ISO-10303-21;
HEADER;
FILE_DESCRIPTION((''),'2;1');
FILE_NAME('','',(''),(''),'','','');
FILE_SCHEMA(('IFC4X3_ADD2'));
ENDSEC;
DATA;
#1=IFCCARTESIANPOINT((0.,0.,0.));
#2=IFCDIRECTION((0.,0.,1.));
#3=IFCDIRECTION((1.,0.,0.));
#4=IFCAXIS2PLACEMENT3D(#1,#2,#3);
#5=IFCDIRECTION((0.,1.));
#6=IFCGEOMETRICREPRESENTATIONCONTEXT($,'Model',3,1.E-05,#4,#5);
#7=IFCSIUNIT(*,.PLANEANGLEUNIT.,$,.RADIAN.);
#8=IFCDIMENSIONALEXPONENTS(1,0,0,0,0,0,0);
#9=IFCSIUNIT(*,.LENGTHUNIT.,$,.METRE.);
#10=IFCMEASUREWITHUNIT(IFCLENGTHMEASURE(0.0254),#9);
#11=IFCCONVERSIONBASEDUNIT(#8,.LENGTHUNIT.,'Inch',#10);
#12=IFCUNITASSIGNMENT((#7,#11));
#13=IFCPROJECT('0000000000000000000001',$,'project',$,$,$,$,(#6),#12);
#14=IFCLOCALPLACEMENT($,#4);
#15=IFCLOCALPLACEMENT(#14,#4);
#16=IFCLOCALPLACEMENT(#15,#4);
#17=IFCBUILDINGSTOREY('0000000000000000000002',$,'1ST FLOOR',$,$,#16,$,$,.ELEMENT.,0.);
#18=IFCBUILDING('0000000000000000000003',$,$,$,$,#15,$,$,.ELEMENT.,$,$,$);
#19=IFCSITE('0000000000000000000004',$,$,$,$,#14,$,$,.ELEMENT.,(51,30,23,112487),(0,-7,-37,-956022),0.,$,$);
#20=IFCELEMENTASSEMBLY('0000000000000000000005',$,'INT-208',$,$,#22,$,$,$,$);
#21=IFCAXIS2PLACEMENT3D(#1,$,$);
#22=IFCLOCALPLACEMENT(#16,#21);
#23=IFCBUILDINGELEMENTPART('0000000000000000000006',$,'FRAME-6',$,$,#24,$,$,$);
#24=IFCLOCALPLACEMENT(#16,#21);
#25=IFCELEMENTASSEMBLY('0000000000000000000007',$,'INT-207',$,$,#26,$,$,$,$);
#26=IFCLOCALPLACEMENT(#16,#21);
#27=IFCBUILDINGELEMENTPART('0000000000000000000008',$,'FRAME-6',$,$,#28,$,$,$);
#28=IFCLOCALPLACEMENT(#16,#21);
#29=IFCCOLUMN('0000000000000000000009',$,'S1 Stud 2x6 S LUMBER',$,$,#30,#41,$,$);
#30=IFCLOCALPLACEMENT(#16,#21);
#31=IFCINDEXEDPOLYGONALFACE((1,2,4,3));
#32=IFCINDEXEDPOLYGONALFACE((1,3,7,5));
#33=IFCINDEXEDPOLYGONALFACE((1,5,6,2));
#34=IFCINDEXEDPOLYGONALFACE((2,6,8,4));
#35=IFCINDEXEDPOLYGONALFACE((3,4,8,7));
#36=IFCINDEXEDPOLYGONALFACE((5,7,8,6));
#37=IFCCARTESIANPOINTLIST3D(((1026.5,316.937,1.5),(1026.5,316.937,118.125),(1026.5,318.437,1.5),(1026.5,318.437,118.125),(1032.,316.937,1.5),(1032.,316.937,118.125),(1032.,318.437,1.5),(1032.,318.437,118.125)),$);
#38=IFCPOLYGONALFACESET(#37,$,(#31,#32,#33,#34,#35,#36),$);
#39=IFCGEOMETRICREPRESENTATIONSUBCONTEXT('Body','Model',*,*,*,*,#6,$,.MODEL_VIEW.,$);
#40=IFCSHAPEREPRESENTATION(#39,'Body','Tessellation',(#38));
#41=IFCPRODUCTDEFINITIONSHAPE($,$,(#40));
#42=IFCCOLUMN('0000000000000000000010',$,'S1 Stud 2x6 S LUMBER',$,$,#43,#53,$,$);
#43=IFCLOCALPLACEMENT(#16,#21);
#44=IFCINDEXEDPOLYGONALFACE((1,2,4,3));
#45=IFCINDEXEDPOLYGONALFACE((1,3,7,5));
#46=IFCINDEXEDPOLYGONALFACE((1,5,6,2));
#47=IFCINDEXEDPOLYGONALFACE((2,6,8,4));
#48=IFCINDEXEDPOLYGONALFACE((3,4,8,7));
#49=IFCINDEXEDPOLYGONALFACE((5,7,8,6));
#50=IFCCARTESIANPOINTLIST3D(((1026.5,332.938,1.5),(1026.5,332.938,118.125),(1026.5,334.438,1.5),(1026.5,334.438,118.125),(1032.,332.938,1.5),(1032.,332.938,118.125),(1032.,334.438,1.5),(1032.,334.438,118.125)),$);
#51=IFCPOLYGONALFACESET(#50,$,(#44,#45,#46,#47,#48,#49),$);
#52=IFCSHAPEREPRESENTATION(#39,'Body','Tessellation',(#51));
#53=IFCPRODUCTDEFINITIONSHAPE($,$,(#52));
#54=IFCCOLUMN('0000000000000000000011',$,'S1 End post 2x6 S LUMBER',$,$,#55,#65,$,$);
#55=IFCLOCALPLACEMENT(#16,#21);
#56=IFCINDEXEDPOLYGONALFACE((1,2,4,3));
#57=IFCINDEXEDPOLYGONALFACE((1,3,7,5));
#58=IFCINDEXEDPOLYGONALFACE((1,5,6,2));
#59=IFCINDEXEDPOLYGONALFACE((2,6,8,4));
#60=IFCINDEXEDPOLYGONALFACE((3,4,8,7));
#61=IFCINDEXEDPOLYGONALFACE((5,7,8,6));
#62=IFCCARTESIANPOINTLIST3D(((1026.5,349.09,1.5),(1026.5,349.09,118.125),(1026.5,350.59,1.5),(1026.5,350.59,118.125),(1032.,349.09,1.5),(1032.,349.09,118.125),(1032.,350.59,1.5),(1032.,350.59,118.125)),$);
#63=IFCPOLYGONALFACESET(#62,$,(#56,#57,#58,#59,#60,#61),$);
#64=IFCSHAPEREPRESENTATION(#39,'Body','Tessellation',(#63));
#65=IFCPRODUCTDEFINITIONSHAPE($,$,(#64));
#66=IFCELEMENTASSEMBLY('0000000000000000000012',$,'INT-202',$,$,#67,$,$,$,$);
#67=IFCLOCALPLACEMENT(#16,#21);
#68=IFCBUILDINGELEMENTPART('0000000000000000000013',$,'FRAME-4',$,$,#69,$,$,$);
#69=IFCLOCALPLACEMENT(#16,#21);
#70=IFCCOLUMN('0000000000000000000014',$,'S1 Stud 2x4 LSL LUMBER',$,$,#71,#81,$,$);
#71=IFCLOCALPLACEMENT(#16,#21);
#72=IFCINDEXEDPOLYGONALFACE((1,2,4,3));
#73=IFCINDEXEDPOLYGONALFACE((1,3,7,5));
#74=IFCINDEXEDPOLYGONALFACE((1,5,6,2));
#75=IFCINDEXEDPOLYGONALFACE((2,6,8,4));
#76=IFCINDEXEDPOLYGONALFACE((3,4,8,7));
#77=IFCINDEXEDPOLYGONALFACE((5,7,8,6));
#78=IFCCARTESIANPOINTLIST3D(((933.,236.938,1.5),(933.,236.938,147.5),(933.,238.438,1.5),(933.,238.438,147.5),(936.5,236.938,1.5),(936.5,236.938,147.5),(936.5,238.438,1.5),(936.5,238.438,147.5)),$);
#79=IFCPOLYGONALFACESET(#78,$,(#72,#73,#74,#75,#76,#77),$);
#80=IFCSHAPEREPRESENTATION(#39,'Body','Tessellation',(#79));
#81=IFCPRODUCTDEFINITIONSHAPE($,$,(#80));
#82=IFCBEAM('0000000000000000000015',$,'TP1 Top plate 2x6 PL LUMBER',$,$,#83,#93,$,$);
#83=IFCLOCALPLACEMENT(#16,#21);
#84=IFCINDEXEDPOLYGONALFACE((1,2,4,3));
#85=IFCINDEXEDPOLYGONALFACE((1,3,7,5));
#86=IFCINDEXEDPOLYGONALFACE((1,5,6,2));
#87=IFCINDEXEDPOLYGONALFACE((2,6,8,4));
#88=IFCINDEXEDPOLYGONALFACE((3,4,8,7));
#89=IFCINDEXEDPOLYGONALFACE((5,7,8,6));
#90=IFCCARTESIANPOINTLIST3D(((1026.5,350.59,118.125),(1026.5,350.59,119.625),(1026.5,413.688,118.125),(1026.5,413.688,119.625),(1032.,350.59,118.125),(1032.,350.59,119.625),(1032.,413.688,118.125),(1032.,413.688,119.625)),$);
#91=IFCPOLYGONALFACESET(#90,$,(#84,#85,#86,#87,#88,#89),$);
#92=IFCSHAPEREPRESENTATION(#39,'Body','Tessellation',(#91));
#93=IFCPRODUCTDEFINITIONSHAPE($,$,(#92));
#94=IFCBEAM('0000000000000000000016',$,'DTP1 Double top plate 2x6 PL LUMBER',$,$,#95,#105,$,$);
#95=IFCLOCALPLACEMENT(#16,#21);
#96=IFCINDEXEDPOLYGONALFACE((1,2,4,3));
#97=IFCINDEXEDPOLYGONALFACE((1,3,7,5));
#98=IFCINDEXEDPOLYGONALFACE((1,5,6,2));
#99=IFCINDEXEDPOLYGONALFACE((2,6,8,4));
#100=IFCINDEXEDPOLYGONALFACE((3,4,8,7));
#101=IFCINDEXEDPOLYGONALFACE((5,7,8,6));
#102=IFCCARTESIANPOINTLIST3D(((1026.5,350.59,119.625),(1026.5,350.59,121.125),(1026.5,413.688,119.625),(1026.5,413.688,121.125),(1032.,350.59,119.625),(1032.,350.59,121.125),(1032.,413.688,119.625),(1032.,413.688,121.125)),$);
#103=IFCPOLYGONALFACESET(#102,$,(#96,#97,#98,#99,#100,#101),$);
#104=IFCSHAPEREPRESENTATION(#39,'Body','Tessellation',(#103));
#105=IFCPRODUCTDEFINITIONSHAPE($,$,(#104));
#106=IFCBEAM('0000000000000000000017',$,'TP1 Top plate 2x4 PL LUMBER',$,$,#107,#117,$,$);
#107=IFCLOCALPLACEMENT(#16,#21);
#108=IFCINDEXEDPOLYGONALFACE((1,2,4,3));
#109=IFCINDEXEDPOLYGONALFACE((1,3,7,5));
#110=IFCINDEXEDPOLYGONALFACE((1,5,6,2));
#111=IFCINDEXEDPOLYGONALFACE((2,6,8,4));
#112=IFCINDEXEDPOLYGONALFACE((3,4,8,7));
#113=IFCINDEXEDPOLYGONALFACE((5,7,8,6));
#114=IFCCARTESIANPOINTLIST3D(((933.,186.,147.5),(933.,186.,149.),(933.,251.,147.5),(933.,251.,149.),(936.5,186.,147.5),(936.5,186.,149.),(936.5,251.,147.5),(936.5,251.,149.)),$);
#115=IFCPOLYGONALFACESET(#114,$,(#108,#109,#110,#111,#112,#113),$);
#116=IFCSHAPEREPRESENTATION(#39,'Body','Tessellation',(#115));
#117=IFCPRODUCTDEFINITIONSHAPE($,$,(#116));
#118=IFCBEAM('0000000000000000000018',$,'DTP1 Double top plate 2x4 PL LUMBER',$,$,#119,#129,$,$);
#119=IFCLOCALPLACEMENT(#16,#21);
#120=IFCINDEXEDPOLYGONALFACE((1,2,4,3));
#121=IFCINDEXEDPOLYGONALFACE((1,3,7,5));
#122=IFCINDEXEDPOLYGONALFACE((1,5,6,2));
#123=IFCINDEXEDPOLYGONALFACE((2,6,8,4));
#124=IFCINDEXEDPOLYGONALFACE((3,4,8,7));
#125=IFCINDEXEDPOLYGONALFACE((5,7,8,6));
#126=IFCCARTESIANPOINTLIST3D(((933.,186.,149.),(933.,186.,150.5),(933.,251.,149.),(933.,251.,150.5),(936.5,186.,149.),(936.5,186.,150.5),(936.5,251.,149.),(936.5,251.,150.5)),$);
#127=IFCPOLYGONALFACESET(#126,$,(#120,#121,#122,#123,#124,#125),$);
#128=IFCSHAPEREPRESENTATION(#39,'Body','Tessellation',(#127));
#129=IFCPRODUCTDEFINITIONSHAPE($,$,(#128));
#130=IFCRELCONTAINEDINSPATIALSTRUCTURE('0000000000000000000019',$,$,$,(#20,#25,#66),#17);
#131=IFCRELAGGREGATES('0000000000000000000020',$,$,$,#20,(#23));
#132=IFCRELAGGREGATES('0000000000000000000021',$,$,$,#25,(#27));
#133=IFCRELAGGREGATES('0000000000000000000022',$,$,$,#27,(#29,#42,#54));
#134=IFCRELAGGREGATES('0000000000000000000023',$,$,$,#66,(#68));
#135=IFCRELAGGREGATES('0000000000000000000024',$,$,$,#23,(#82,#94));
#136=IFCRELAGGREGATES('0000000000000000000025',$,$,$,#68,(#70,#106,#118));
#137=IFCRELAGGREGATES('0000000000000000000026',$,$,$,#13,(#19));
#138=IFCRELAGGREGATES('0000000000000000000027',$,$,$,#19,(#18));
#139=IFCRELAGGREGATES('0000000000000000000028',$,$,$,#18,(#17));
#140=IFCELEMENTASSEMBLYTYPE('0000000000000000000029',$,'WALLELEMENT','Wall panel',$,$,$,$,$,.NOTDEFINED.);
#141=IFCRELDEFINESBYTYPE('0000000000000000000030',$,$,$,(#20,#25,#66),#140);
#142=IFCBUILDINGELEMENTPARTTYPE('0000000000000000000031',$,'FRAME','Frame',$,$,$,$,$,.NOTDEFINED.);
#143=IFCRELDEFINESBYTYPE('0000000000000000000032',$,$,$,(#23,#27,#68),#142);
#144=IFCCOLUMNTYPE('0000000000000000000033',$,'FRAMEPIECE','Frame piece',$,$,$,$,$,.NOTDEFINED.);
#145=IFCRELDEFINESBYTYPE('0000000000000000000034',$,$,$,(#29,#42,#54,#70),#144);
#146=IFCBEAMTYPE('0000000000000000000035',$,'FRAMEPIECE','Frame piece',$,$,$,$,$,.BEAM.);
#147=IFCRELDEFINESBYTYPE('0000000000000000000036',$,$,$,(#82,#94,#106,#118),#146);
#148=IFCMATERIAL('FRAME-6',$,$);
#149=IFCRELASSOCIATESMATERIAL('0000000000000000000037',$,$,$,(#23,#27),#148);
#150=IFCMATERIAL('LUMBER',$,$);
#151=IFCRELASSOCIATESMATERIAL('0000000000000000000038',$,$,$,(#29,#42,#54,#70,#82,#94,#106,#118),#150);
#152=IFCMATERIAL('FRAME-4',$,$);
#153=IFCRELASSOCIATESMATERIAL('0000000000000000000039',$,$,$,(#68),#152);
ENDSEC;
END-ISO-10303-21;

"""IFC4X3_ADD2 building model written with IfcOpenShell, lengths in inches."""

from ifc_helpers import new_model, entity, si_unit, converted_unit, direction, frame, origin_with_axes, origin_2d_with_axis, place, context, subcontext, project, spatial, rectangle, extrude, material, type_object, element, aggregate, save


model = new_model("IFC4X3_ADD2")

# Units and contexts
model_context = context("Model", 3, precision=1e-05, world=origin_with_axes(), true_north=direction((0.0, 1.0)))
body_context = subcontext(model_context, "Body", "Model", "MODEL_VIEW")
ifc_project = project(units=[si_unit("PLANEANGLEUNIT", "RADIAN"), converted_unit("LENGTHUNIT", "Inch", entity("IfcLengthMeasure", 0.0254), si_unit("LENGTHUNIT", "METRE"), dimensions=[1, 0, 0, 0, 0, 0, 0])], contexts=[model_context])

# Site, building, storey
site_placement = place(None, origin_with_axes())
site = spatial("IfcSite", under=ifc_project, at=site_placement, CompositionType="ELEMENT", RefLatitude=(51, 30, 23, 112487), RefLongitude=(0, -7, -37, -956022), RefElevation=0.0)
building_placement = place(site_placement, origin_with_axes())
building = spatial("IfcBuilding", under=site, at=building_placement, CompositionType="ELEMENT")
storey_placement = place(building_placement, origin_with_axes())
storey = spatial("IfcBuildingStorey", under=building, at=storey_placement, Name="1ST FLOOR", CompositionType="ELEMENT", Elevation=0.0)

# Element assembly, building element part
element_assembly_type = type_object("IfcElementAssemblyType", Name="WALLELEMENT", Description="Wall panel", PredefinedType="NOTDEFINED")
assembly_1_placement = place(storey_placement, origin_with_axes())
assembly_1 = element("IfcElementAssembly", 1, at=assembly_1_placement, inside=storey, type_object=element_assembly_type, Name="INT-208")
ifc_material_1 = material(Name="FRAME-6")
building_element_part_type = type_object("IfcBuildingElementPartType", Name="FRAME", Description="Frame", PredefinedType="NOTDEFINED")
building_element_part_1_placement = place(storey_placement, origin_with_axes())
building_element_part_1 = element("IfcBuildingElementPart", 2, at=building_element_part_1_placement, type_object=building_element_part_type, material=ifc_material_1, Name="FRAME-6")
aggregate(assembly_1, [building_element_part_1])
ifc_material_2 = material(Name="LUMBER")
column_type = type_object("IfcColumnType", Name="FRAMEPIECE", Description="Frame piece", PredefinedType="NOTDEFINED")

# Element assembly, building element part, columns
ifc_material_3 = material(Name="FRAME-4")
assembly_2_placement = place(storey_placement, origin_with_axes())
assembly_2 = element("IfcElementAssembly", 3, at=assembly_2_placement, inside=storey, type_object=element_assembly_type, Name="INT-207")
building_element_part_2_placement = place(storey_placement, origin_with_axes())
building_element_part_2 = element("IfcBuildingElementPart", 4, at=building_element_part_2_placement, type_object=building_element_part_type, material=ifc_material_1, Name="FRAME-6")
aggregate(assembly_2, [building_element_part_2])
column_1_placement = place(storey_placement, frame((1029.25, 317.688, 118.125), z_axis=(0.0, 0.0, -1.0), x_axis=(0.0, -1.0, 0.0)))
column_1 = element("IfcColumn", 5, at=column_1_placement, type_object=column_type, material=ifc_material_2, Name="S1 Stud 2x6 S LUMBER", context=body_context, shape_type="SweptSolid", body=[
    extrude(rectangle(XDim=1.5, YDim=5.5, at=origin_2d_with_axis()), origin_with_axes(), (0.0, 0.0, 1.0), 116.625),
])
column_2_placement = place(storey_placement, frame((1029.25, 333.688, 118.125), z_axis=(0.0, 0.0, -1.0), x_axis=(0.0, -1.0, 0.0)))
column_2 = element("IfcColumn", 6, at=column_2_placement, type_object=column_type, material=ifc_material_2, Name="S1 Stud 2x6 S LUMBER", context=body_context, shape_type="SweptSolid", body=[
    extrude(rectangle(XDim=1.5, YDim=5.5, at=origin_2d_with_axis()), origin_with_axes(), (0.0, 0.0, 1.0), 116.625),
])
column_3_placement = place(storey_placement, frame((1029.25, 349.84, 118.125), z_axis=(0.0, 0.0, -1.0), x_axis=(0.0, -1.0, 0.0)))
column_3 = element("IfcColumn", 7, at=column_3_placement, type_object=column_type, material=ifc_material_2, Name="S1 End post 2x6 S LUMBER", context=body_context, shape_type="SweptSolid", body=[
    extrude(rectangle(XDim=1.5, YDim=5.5, at=origin_2d_with_axis()), origin_with_axes(), (0.0, 0.0, 1.0), 116.625),
])
aggregate(building_element_part_2, [column_1, column_2, column_3])

# Element assembly, building element part, column
assembly_3_placement = place(storey_placement, origin_with_axes())
assembly_3 = element("IfcElementAssembly", 8, at=assembly_3_placement, inside=storey, type_object=element_assembly_type, Name="INT-202")
building_element_part_3_placement = place(storey_placement, origin_with_axes())
building_element_part_3 = element("IfcBuildingElementPart", 9, at=building_element_part_3_placement, type_object=building_element_part_type, material=ifc_material_3, Name="FRAME-4")
aggregate(assembly_3, [building_element_part_3])
column_4_placement = place(storey_placement, frame((934.75, 237.688, 147.5), z_axis=(0.0, 0.0, -1.0), x_axis=(0.0, 1.0, 0.0)))
column_4 = element("IfcColumn", 10, at=column_4_placement, type_object=column_type, material=ifc_material_2, Name="S1 Stud 2x4 LSL LUMBER", context=body_context, shape_type="SweptSolid", body=[
    extrude(rectangle(XDim=1.5, YDim=3.5, at=origin_2d_with_axis()), origin_with_axes(), (0.0, 0.0, 1.0), 146.0),
])

# Beams
beam_type = type_object("IfcBeamType", Name="FRAMEPIECE", Description="Frame piece", PredefinedType="BEAM")
beam_1_placement = place(storey_placement, frame((1029.25, 350.59, 118.875), z_axis=(0.0, 1.0, 0.0), x_axis=(0.0, 0.0, -1.0)))
beam_1 = element("IfcBeam", 11, at=beam_1_placement, type_object=beam_type, material=ifc_material_2, Name="TP1 Top plate 2x6 PL LUMBER", context=body_context, shape_type="SweptSolid", body=[
    extrude(rectangle(XDim=1.5, YDim=5.5, at=origin_2d_with_axis()), origin_with_axes(), (0.0, 0.0, 1.0), 63.098),
])
beam_2_placement = place(storey_placement, frame((1029.25, 350.59, 120.375), z_axis=(0.0, 1.0, 0.0), x_axis=(0.0, 0.0, -1.0)))
beam_2 = element("IfcBeam", 12, at=beam_2_placement, type_object=beam_type, material=ifc_material_2, Name="DTP1 Double top plate 2x6 PL LUMBER", context=body_context, shape_type="SweptSolid", body=[
    extrude(rectangle(XDim=1.5, YDim=5.5, at=origin_2d_with_axis()), origin_with_axes(), (0.0, 0.0, 1.0), 63.098),
])
aggregate(building_element_part_1, [beam_1, beam_2])
beam_3_placement = place(storey_placement, frame((934.75, 251.0, 148.25), z_axis=(0.0, -1.0, 0.0), x_axis=(0.0, 0.0, -1.0)))
beam_3 = element("IfcBeam", 13, at=beam_3_placement, type_object=beam_type, material=ifc_material_2, Name="TP1 Top plate 2x4 PL LUMBER", context=body_context, shape_type="SweptSolid", body=[
    extrude(rectangle(XDim=1.5, YDim=3.5, at=origin_2d_with_axis()), origin_with_axes(), (0.0, 0.0, 1.0), 65.0),
])
beam_4_placement = place(storey_placement, frame((934.75, 251.0, 149.75), z_axis=(0.0, -1.0, 0.0), x_axis=(0.0, 0.0, -1.0)))
beam_4 = element("IfcBeam", 14, at=beam_4_placement, type_object=beam_type, material=ifc_material_2, Name="DTP1 Double top plate 2x4 PL LUMBER", context=body_context, shape_type="SweptSolid", body=[
    extrude(rectangle(XDim=1.5, YDim=3.5, at=origin_2d_with_axis()), origin_with_axes(), (0.0, 0.0, 1.0), 65.0),
])
aggregate(building_element_part_3, [column_4, beam_3, beam_4])

save(model, "model.ifc")
